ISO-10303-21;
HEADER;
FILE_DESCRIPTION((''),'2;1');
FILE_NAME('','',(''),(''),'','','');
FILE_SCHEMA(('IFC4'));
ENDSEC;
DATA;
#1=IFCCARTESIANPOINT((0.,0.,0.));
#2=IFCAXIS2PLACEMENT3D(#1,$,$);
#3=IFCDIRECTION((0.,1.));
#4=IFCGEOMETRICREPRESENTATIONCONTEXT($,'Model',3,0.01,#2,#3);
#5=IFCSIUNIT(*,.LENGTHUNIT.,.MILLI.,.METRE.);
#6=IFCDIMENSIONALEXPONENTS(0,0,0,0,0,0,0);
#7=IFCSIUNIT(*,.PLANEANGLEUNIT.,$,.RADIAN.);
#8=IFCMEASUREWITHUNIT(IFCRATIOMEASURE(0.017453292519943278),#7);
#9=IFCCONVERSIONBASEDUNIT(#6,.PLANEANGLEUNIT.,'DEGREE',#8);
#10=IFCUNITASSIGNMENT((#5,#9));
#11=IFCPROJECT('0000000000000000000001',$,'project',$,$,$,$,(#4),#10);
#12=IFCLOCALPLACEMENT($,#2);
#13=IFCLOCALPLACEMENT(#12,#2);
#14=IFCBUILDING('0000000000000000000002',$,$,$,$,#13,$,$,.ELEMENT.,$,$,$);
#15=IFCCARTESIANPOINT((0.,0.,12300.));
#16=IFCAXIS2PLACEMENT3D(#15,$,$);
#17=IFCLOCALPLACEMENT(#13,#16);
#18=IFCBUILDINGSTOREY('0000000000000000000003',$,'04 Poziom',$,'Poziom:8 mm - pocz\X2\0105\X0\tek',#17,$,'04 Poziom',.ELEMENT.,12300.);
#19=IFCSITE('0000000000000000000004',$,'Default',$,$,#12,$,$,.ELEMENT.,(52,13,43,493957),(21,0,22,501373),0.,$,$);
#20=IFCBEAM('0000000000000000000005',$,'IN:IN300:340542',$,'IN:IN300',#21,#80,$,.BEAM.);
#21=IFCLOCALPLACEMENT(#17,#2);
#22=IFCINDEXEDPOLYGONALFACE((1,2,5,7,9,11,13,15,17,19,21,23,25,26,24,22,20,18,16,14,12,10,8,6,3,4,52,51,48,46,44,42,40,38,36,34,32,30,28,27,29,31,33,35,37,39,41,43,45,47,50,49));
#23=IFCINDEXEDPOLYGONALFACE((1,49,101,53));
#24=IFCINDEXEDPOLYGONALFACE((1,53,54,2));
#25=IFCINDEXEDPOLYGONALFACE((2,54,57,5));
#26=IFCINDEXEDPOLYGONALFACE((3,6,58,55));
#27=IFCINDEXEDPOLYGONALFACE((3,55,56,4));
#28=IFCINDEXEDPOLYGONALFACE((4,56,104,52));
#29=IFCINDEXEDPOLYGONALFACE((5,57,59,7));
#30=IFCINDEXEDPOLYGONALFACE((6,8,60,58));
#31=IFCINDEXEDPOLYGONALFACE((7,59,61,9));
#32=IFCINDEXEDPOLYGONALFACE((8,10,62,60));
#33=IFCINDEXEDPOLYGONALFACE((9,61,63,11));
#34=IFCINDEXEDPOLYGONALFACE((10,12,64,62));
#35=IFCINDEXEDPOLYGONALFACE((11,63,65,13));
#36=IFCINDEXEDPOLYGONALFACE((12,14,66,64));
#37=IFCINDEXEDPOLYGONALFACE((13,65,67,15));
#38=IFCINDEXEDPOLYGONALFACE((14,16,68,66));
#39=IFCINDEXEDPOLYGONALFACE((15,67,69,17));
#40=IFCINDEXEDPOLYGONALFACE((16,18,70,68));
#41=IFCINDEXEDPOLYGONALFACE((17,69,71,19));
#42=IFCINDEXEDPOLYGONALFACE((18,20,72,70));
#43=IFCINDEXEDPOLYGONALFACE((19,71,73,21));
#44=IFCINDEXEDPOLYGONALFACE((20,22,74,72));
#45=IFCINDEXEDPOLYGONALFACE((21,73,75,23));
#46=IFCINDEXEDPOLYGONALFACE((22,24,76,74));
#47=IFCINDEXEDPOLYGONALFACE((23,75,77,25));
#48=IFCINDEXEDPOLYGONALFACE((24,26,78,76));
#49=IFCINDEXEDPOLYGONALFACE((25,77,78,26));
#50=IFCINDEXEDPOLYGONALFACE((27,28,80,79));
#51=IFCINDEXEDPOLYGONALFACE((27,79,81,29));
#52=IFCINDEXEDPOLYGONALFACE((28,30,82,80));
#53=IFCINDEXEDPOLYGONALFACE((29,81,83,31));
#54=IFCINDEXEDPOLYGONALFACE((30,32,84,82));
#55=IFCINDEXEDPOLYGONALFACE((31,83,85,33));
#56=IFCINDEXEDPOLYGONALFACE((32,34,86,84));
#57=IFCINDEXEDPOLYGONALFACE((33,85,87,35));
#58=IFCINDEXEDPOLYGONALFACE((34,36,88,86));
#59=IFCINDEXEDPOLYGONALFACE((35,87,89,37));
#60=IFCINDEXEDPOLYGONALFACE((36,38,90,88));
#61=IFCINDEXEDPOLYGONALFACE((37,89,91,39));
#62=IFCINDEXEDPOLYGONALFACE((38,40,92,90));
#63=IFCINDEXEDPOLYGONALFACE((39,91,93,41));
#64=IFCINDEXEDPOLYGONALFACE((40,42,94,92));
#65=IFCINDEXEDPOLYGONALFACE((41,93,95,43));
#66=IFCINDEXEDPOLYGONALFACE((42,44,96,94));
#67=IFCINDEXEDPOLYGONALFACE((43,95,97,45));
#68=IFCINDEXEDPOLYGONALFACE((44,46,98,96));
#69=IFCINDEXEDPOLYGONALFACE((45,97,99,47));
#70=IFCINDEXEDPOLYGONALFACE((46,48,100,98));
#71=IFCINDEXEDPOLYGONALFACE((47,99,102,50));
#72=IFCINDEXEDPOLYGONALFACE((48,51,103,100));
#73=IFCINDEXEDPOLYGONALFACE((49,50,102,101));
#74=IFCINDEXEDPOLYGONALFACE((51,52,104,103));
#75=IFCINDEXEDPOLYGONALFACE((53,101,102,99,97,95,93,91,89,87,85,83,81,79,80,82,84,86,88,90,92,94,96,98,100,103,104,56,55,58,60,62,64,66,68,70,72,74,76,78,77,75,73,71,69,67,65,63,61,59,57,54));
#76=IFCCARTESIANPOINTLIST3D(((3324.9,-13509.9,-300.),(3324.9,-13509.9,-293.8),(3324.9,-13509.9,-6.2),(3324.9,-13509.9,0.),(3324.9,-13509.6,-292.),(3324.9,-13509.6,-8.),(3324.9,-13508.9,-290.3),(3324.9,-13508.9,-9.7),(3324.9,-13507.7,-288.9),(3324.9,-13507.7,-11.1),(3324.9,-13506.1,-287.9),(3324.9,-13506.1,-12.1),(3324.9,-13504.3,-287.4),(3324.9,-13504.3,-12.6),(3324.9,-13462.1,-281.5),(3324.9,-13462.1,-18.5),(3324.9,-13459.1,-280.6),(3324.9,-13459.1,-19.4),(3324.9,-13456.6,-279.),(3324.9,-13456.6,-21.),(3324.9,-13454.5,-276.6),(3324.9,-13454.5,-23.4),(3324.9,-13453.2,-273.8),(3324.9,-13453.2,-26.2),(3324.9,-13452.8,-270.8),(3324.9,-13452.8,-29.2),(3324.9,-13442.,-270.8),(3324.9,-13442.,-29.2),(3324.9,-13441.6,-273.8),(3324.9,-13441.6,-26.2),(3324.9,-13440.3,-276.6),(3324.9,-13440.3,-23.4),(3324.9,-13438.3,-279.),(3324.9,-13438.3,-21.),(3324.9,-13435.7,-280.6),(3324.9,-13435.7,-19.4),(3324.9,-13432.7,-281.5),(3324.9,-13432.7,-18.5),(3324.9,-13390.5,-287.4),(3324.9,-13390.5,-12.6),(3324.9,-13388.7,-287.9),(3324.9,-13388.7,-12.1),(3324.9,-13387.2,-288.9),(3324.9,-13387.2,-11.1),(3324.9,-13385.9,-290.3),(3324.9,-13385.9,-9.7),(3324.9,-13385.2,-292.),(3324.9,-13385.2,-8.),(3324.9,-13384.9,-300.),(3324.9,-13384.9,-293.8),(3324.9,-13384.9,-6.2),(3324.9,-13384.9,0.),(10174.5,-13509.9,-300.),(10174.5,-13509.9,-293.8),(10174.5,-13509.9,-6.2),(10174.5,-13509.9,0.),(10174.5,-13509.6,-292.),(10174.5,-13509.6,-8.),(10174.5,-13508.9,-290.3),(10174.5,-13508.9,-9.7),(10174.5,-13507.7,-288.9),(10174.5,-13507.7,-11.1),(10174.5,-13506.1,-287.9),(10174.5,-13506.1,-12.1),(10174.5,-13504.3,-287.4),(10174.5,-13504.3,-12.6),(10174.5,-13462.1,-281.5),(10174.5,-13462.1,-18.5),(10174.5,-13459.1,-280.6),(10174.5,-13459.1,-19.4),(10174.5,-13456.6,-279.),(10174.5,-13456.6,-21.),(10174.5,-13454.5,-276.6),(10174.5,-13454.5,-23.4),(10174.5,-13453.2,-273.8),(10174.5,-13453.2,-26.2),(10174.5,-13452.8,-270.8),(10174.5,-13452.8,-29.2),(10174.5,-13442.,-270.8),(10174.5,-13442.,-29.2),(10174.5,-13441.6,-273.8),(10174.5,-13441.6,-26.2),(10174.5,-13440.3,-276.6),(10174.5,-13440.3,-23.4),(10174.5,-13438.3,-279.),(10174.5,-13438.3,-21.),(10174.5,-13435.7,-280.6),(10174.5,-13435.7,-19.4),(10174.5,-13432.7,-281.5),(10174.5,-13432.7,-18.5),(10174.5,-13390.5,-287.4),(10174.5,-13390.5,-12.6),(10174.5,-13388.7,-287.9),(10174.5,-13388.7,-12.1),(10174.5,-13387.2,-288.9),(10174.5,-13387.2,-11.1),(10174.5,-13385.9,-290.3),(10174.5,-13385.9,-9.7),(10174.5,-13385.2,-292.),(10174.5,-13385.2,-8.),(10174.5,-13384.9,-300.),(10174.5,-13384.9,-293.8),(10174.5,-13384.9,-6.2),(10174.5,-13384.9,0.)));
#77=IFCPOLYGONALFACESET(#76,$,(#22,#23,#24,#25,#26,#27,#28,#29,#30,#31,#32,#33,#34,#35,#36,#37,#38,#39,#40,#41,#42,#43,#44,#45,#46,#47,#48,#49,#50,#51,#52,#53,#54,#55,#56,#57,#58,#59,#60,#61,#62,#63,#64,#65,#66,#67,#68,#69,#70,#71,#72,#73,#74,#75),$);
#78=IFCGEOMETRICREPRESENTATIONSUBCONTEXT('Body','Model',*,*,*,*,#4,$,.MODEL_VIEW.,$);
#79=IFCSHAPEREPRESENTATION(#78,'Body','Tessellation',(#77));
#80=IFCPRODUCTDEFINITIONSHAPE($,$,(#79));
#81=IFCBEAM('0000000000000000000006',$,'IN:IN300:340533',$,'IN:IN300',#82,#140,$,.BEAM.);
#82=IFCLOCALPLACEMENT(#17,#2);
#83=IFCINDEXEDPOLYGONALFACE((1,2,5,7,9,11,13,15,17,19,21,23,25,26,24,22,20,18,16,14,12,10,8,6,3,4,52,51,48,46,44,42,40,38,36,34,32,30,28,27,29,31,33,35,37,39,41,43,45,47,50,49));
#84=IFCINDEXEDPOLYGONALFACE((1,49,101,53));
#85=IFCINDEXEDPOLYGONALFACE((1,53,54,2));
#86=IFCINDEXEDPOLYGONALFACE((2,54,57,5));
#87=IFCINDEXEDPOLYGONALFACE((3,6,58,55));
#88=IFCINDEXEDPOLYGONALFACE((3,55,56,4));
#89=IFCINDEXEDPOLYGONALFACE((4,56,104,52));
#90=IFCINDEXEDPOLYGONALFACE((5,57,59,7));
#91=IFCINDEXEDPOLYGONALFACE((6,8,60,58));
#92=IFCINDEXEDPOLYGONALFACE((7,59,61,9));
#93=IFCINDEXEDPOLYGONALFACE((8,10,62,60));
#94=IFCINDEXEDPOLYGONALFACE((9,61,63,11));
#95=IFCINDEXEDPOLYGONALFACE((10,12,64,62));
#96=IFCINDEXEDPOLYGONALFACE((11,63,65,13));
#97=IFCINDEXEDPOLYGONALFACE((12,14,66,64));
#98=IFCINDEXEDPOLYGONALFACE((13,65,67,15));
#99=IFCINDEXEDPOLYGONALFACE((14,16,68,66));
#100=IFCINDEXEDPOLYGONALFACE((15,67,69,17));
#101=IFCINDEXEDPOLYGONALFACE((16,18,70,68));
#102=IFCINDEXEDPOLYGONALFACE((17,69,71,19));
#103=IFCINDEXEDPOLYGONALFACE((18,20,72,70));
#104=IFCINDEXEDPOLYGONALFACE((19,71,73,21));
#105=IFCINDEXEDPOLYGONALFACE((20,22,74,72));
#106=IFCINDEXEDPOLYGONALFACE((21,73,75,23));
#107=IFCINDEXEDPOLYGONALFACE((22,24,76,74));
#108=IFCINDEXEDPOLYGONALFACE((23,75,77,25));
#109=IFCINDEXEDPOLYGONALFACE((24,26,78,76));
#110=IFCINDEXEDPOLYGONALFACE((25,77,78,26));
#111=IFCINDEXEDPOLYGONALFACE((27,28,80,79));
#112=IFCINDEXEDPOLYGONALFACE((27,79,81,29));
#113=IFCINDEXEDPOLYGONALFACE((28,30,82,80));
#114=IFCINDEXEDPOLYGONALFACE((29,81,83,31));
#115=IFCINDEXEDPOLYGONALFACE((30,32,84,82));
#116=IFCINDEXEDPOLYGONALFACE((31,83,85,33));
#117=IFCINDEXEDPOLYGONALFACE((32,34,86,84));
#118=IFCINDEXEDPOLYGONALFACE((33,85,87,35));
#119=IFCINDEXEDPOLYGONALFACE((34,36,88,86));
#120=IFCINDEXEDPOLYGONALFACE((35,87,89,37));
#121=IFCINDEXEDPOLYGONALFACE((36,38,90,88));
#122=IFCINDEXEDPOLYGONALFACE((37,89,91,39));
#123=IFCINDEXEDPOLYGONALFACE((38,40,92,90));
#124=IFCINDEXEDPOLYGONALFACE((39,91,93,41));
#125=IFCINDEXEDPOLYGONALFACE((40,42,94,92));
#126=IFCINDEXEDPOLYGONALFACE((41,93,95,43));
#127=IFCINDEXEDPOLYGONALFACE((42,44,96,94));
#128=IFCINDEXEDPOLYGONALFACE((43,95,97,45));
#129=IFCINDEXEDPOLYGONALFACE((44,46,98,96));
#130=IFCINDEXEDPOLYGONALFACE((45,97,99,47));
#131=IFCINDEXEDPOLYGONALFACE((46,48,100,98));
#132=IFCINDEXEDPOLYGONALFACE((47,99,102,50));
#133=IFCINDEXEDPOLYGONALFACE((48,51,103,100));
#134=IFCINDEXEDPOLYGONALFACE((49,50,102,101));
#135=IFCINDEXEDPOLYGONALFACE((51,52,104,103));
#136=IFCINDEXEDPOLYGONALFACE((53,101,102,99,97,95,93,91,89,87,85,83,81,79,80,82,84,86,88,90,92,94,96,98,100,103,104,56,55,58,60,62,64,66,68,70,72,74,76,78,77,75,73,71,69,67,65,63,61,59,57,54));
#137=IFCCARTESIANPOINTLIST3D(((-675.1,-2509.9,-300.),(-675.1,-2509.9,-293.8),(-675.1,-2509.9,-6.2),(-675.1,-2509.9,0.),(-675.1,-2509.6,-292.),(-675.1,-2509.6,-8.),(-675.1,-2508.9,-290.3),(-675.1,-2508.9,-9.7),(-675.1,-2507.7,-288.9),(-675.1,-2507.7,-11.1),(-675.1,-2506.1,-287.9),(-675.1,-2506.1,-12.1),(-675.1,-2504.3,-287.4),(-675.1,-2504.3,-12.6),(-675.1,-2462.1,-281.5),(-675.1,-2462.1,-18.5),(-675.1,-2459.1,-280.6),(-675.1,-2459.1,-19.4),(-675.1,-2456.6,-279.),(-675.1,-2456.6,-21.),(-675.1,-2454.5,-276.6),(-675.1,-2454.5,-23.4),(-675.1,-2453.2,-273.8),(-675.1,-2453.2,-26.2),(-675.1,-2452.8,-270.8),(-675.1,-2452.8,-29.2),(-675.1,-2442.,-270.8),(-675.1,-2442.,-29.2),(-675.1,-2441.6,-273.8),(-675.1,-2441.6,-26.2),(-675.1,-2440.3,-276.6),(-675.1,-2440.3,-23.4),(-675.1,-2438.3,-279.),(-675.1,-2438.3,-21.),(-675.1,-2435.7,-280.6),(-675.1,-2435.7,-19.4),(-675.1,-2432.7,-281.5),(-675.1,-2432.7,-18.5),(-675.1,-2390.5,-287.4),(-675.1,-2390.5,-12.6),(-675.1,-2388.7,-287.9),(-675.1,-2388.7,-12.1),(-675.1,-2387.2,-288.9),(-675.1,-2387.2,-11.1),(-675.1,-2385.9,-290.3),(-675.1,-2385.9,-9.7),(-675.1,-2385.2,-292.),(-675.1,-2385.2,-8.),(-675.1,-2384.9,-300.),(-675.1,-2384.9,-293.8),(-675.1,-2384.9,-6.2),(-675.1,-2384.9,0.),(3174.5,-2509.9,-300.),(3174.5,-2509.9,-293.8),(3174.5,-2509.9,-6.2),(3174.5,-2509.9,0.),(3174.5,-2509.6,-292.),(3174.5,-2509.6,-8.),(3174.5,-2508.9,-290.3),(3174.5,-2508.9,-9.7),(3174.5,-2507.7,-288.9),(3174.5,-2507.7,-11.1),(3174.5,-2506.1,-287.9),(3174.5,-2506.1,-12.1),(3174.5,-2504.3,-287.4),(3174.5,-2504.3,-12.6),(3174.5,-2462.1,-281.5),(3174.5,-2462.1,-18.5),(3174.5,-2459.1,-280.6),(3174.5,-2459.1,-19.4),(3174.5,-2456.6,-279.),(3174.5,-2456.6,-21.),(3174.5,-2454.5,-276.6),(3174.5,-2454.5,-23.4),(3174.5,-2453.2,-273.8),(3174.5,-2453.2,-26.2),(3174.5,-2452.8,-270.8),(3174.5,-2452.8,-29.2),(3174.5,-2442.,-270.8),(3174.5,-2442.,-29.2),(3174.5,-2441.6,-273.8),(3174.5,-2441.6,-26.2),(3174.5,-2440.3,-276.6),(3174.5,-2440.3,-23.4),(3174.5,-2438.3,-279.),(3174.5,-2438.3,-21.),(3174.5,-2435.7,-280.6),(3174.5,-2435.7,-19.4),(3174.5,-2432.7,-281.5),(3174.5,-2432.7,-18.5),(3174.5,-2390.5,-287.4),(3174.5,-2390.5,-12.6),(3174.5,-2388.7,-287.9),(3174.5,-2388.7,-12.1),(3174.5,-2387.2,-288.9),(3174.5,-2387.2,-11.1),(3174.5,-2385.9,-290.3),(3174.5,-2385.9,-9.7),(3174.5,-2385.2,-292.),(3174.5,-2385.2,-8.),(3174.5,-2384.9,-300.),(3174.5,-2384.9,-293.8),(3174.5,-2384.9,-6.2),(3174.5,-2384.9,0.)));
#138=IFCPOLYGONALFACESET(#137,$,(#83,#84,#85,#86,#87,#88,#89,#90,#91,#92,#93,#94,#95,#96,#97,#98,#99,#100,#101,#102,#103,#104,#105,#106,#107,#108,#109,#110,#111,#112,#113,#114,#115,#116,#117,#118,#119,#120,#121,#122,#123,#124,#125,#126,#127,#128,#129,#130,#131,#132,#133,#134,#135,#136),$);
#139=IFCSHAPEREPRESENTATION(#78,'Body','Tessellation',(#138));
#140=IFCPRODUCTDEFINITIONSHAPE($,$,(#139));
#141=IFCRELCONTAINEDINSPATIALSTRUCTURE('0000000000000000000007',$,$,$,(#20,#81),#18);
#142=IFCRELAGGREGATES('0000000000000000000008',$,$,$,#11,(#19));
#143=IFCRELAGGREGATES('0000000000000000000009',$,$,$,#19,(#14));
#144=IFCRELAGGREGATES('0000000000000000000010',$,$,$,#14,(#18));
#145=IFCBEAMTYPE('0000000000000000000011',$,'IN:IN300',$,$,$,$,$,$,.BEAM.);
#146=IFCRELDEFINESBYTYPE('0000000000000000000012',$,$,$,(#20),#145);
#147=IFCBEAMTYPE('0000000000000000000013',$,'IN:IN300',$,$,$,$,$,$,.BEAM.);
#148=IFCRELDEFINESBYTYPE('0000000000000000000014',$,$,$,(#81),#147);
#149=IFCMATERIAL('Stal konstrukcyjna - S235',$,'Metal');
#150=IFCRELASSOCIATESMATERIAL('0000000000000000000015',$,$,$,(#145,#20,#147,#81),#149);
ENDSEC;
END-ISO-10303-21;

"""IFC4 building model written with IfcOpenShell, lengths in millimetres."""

from ifc_helpers import new_model, entity, si_unit, converted_unit, direction, frame, origin, place, context, subcontext, project, spatial, line, arc, indexed_curve, outline, extrude, source, transform, mapped, material, type_object, type_shapes, element, save


model = new_model("IFC4")

# Units and contexts
model_context = context("Model", 3, precision=0.01, world=origin(), true_north=direction((0.0, 1.0)))
body_context = subcontext(model_context, "Body", "Model", "MODEL_VIEW")
ifc_project = project(units=[si_unit("LENGTHUNIT", "METRE", prefix="MILLI"), converted_unit("PLANEANGLEUNIT", "DEGREE", entity("IfcRatioMeasure", 0.017453292519943278), si_unit("PLANEANGLEUNIT", "RADIAN"), dimensions=[0, 0, 0, 0, 0, 0, 0])], contexts=[model_context])

# Site, building, storey
site_placement = place(None, origin())
site = spatial("IfcSite", under=ifc_project, at=site_placement, Name="Default", CompositionType="ELEMENT", RefLatitude=(52, 13, 43, 493957), RefLongitude=(21, 0, 22, 501373), RefElevation=0.0)
building_placement = place(site_placement, origin())
building = spatial("IfcBuilding", under=site, at=building_placement, CompositionType="ELEMENT")
storey_placement = place(building_placement, frame((0.0, 0.0, 12300.0)))
storey = spatial("IfcBuildingStorey", under=building, at=storey_placement, Name="04 Poziom", ObjectType="Poziom:8 mm - początek", LongName="04 Poziom", CompositionType="ELEMENT", Elevation=12300.0)

# Shared definitions
ifc_material = material(Name="Stal konstrukcyjna - S235", Category="Metal")

# Beams
beam_type_1 = type_object("IfcBeamType", Name="IN:IN300", PredefinedType="BEAM", material=ifc_material)
shared_shape_1 = source(origin(), body_context, "Body", "SweptSolid", [
    extrude(outline(indexed_curve([(143.8, -62.5), (150.0, -62.5), (150.0, 62.5), (143.8, 62.5), (139.6, 60.9), (137.4, 56.9), (131.5, 14.7), (127.9, 8.1), (120.8, 5.4), (-120.8, 5.4), (-127.9, 8.1), (-131.5, 14.7), (-137.4, 56.9), (-139.6, 60.9), (-143.8, 62.5), (-150.0, 62.5), (-150.0, -62.5), (-143.8, -62.5), (-139.6, -60.9), (-137.4, -56.9), (-131.5, -14.7), (-127.9, -8.1), (-120.8, -5.4), (120.8, -5.4), (127.9, -8.1), (131.5, -14.7), (137.4, -56.9), (139.6, -60.9)], segments=[line(1, 2, 3, 4), arc(4, 5, 6), line(6, 7), arc(7, 8, 9), line(9, 10), arc(10, 11, 12), line(12, 13), arc(13, 14, 15), line(15, 16, 17, 18), arc(18, 19, 20), line(20, 21), arc(21, 22, 23), line(23, 24), arc(24, 25, 26), line(26, 27), arc(27, 28, 1)], self_intersect=False)), frame((-3424.8, 0.0, 0.0), z_axis=(1.0, 0.0, 0.0), x_axis=(0.0, 0.0, -1.0)), (0.0, 0.0, 1.0), 6849.6),
])
type_shapes(beam_type_1, [shared_shape_1])
for number, where, name in (
    (1, (6749.7, -13447.4, -150.0), "IN:IN300:340542"),
):
    element("IfcBeam", number, at=place(storey_placement, frame(where)), inside=storey, type_object=beam_type_1, material=ifc_material, Name=name, ObjectType="IN:IN300", PredefinedType="BEAM", context=body_context, shape_type="MappedRepresentation", body=[
        mapped(shared_shape_1, transform((0.0, 0.0, 0.0), scale=1.0)),
    ])
beam_type_2 = type_object("IfcBeamType", Name="IN:IN300", PredefinedType="BEAM", material=ifc_material)
shared_shape_2 = source(origin(), body_context, "Body", "SweptSolid", [
    extrude(outline(indexed_curve([(143.8, -62.5), (150.0, -62.5), (150.0, 62.5), (143.8, 62.5), (139.6, 60.9), (137.4, 56.9), (131.5, 14.7), (127.9, 8.1), (120.8, 5.4), (-120.8, 5.4), (-127.9, 8.1), (-131.5, 14.7), (-137.4, 56.9), (-139.6, 60.9), (-143.8, 62.5), (-150.0, 62.5), (-150.0, -62.5), (-143.8, -62.5), (-139.6, -60.9), (-137.4, -56.9), (-131.5, -14.7), (-127.9, -8.1), (-120.8, -5.4), (120.8, -5.4), (127.9, -8.1), (131.5, -14.7), (137.4, -56.9), (139.6, -60.9)], segments=[line(1, 2, 3, 4), arc(4, 5, 6), line(6, 7), arc(7, 8, 9), line(9, 10), arc(10, 11, 12), line(12, 13), arc(13, 14, 15), line(15, 16, 17, 18), arc(18, 19, 20), line(20, 21), arc(21, 22, 23), line(23, 24), arc(24, 25, 26), line(26, 27), arc(27, 28, 1)], self_intersect=False)), frame((-1924.8, 0.0, 0.0), z_axis=(1.0, 0.0, 0.0), x_axis=(0.0, 0.0, -1.0)), (0.0, 0.0, 1.0), 3849.6),
])
type_shapes(beam_type_2, [shared_shape_2])
for number, where, name in (
    (2, (1249.7, -2447.4, -150.0), "IN:IN300:340533"),
):
    element("IfcBeam", number, at=place(storey_placement, frame(where)), inside=storey, type_object=beam_type_2, material=ifc_material, Name=name, ObjectType="IN:IN300", PredefinedType="BEAM", context=body_context, shape_type="MappedRepresentation", body=[
        mapped(shared_shape_2, transform((0.0, 0.0, 0.0), scale=1.0)),
    ])

save(model, "model.ifc")
